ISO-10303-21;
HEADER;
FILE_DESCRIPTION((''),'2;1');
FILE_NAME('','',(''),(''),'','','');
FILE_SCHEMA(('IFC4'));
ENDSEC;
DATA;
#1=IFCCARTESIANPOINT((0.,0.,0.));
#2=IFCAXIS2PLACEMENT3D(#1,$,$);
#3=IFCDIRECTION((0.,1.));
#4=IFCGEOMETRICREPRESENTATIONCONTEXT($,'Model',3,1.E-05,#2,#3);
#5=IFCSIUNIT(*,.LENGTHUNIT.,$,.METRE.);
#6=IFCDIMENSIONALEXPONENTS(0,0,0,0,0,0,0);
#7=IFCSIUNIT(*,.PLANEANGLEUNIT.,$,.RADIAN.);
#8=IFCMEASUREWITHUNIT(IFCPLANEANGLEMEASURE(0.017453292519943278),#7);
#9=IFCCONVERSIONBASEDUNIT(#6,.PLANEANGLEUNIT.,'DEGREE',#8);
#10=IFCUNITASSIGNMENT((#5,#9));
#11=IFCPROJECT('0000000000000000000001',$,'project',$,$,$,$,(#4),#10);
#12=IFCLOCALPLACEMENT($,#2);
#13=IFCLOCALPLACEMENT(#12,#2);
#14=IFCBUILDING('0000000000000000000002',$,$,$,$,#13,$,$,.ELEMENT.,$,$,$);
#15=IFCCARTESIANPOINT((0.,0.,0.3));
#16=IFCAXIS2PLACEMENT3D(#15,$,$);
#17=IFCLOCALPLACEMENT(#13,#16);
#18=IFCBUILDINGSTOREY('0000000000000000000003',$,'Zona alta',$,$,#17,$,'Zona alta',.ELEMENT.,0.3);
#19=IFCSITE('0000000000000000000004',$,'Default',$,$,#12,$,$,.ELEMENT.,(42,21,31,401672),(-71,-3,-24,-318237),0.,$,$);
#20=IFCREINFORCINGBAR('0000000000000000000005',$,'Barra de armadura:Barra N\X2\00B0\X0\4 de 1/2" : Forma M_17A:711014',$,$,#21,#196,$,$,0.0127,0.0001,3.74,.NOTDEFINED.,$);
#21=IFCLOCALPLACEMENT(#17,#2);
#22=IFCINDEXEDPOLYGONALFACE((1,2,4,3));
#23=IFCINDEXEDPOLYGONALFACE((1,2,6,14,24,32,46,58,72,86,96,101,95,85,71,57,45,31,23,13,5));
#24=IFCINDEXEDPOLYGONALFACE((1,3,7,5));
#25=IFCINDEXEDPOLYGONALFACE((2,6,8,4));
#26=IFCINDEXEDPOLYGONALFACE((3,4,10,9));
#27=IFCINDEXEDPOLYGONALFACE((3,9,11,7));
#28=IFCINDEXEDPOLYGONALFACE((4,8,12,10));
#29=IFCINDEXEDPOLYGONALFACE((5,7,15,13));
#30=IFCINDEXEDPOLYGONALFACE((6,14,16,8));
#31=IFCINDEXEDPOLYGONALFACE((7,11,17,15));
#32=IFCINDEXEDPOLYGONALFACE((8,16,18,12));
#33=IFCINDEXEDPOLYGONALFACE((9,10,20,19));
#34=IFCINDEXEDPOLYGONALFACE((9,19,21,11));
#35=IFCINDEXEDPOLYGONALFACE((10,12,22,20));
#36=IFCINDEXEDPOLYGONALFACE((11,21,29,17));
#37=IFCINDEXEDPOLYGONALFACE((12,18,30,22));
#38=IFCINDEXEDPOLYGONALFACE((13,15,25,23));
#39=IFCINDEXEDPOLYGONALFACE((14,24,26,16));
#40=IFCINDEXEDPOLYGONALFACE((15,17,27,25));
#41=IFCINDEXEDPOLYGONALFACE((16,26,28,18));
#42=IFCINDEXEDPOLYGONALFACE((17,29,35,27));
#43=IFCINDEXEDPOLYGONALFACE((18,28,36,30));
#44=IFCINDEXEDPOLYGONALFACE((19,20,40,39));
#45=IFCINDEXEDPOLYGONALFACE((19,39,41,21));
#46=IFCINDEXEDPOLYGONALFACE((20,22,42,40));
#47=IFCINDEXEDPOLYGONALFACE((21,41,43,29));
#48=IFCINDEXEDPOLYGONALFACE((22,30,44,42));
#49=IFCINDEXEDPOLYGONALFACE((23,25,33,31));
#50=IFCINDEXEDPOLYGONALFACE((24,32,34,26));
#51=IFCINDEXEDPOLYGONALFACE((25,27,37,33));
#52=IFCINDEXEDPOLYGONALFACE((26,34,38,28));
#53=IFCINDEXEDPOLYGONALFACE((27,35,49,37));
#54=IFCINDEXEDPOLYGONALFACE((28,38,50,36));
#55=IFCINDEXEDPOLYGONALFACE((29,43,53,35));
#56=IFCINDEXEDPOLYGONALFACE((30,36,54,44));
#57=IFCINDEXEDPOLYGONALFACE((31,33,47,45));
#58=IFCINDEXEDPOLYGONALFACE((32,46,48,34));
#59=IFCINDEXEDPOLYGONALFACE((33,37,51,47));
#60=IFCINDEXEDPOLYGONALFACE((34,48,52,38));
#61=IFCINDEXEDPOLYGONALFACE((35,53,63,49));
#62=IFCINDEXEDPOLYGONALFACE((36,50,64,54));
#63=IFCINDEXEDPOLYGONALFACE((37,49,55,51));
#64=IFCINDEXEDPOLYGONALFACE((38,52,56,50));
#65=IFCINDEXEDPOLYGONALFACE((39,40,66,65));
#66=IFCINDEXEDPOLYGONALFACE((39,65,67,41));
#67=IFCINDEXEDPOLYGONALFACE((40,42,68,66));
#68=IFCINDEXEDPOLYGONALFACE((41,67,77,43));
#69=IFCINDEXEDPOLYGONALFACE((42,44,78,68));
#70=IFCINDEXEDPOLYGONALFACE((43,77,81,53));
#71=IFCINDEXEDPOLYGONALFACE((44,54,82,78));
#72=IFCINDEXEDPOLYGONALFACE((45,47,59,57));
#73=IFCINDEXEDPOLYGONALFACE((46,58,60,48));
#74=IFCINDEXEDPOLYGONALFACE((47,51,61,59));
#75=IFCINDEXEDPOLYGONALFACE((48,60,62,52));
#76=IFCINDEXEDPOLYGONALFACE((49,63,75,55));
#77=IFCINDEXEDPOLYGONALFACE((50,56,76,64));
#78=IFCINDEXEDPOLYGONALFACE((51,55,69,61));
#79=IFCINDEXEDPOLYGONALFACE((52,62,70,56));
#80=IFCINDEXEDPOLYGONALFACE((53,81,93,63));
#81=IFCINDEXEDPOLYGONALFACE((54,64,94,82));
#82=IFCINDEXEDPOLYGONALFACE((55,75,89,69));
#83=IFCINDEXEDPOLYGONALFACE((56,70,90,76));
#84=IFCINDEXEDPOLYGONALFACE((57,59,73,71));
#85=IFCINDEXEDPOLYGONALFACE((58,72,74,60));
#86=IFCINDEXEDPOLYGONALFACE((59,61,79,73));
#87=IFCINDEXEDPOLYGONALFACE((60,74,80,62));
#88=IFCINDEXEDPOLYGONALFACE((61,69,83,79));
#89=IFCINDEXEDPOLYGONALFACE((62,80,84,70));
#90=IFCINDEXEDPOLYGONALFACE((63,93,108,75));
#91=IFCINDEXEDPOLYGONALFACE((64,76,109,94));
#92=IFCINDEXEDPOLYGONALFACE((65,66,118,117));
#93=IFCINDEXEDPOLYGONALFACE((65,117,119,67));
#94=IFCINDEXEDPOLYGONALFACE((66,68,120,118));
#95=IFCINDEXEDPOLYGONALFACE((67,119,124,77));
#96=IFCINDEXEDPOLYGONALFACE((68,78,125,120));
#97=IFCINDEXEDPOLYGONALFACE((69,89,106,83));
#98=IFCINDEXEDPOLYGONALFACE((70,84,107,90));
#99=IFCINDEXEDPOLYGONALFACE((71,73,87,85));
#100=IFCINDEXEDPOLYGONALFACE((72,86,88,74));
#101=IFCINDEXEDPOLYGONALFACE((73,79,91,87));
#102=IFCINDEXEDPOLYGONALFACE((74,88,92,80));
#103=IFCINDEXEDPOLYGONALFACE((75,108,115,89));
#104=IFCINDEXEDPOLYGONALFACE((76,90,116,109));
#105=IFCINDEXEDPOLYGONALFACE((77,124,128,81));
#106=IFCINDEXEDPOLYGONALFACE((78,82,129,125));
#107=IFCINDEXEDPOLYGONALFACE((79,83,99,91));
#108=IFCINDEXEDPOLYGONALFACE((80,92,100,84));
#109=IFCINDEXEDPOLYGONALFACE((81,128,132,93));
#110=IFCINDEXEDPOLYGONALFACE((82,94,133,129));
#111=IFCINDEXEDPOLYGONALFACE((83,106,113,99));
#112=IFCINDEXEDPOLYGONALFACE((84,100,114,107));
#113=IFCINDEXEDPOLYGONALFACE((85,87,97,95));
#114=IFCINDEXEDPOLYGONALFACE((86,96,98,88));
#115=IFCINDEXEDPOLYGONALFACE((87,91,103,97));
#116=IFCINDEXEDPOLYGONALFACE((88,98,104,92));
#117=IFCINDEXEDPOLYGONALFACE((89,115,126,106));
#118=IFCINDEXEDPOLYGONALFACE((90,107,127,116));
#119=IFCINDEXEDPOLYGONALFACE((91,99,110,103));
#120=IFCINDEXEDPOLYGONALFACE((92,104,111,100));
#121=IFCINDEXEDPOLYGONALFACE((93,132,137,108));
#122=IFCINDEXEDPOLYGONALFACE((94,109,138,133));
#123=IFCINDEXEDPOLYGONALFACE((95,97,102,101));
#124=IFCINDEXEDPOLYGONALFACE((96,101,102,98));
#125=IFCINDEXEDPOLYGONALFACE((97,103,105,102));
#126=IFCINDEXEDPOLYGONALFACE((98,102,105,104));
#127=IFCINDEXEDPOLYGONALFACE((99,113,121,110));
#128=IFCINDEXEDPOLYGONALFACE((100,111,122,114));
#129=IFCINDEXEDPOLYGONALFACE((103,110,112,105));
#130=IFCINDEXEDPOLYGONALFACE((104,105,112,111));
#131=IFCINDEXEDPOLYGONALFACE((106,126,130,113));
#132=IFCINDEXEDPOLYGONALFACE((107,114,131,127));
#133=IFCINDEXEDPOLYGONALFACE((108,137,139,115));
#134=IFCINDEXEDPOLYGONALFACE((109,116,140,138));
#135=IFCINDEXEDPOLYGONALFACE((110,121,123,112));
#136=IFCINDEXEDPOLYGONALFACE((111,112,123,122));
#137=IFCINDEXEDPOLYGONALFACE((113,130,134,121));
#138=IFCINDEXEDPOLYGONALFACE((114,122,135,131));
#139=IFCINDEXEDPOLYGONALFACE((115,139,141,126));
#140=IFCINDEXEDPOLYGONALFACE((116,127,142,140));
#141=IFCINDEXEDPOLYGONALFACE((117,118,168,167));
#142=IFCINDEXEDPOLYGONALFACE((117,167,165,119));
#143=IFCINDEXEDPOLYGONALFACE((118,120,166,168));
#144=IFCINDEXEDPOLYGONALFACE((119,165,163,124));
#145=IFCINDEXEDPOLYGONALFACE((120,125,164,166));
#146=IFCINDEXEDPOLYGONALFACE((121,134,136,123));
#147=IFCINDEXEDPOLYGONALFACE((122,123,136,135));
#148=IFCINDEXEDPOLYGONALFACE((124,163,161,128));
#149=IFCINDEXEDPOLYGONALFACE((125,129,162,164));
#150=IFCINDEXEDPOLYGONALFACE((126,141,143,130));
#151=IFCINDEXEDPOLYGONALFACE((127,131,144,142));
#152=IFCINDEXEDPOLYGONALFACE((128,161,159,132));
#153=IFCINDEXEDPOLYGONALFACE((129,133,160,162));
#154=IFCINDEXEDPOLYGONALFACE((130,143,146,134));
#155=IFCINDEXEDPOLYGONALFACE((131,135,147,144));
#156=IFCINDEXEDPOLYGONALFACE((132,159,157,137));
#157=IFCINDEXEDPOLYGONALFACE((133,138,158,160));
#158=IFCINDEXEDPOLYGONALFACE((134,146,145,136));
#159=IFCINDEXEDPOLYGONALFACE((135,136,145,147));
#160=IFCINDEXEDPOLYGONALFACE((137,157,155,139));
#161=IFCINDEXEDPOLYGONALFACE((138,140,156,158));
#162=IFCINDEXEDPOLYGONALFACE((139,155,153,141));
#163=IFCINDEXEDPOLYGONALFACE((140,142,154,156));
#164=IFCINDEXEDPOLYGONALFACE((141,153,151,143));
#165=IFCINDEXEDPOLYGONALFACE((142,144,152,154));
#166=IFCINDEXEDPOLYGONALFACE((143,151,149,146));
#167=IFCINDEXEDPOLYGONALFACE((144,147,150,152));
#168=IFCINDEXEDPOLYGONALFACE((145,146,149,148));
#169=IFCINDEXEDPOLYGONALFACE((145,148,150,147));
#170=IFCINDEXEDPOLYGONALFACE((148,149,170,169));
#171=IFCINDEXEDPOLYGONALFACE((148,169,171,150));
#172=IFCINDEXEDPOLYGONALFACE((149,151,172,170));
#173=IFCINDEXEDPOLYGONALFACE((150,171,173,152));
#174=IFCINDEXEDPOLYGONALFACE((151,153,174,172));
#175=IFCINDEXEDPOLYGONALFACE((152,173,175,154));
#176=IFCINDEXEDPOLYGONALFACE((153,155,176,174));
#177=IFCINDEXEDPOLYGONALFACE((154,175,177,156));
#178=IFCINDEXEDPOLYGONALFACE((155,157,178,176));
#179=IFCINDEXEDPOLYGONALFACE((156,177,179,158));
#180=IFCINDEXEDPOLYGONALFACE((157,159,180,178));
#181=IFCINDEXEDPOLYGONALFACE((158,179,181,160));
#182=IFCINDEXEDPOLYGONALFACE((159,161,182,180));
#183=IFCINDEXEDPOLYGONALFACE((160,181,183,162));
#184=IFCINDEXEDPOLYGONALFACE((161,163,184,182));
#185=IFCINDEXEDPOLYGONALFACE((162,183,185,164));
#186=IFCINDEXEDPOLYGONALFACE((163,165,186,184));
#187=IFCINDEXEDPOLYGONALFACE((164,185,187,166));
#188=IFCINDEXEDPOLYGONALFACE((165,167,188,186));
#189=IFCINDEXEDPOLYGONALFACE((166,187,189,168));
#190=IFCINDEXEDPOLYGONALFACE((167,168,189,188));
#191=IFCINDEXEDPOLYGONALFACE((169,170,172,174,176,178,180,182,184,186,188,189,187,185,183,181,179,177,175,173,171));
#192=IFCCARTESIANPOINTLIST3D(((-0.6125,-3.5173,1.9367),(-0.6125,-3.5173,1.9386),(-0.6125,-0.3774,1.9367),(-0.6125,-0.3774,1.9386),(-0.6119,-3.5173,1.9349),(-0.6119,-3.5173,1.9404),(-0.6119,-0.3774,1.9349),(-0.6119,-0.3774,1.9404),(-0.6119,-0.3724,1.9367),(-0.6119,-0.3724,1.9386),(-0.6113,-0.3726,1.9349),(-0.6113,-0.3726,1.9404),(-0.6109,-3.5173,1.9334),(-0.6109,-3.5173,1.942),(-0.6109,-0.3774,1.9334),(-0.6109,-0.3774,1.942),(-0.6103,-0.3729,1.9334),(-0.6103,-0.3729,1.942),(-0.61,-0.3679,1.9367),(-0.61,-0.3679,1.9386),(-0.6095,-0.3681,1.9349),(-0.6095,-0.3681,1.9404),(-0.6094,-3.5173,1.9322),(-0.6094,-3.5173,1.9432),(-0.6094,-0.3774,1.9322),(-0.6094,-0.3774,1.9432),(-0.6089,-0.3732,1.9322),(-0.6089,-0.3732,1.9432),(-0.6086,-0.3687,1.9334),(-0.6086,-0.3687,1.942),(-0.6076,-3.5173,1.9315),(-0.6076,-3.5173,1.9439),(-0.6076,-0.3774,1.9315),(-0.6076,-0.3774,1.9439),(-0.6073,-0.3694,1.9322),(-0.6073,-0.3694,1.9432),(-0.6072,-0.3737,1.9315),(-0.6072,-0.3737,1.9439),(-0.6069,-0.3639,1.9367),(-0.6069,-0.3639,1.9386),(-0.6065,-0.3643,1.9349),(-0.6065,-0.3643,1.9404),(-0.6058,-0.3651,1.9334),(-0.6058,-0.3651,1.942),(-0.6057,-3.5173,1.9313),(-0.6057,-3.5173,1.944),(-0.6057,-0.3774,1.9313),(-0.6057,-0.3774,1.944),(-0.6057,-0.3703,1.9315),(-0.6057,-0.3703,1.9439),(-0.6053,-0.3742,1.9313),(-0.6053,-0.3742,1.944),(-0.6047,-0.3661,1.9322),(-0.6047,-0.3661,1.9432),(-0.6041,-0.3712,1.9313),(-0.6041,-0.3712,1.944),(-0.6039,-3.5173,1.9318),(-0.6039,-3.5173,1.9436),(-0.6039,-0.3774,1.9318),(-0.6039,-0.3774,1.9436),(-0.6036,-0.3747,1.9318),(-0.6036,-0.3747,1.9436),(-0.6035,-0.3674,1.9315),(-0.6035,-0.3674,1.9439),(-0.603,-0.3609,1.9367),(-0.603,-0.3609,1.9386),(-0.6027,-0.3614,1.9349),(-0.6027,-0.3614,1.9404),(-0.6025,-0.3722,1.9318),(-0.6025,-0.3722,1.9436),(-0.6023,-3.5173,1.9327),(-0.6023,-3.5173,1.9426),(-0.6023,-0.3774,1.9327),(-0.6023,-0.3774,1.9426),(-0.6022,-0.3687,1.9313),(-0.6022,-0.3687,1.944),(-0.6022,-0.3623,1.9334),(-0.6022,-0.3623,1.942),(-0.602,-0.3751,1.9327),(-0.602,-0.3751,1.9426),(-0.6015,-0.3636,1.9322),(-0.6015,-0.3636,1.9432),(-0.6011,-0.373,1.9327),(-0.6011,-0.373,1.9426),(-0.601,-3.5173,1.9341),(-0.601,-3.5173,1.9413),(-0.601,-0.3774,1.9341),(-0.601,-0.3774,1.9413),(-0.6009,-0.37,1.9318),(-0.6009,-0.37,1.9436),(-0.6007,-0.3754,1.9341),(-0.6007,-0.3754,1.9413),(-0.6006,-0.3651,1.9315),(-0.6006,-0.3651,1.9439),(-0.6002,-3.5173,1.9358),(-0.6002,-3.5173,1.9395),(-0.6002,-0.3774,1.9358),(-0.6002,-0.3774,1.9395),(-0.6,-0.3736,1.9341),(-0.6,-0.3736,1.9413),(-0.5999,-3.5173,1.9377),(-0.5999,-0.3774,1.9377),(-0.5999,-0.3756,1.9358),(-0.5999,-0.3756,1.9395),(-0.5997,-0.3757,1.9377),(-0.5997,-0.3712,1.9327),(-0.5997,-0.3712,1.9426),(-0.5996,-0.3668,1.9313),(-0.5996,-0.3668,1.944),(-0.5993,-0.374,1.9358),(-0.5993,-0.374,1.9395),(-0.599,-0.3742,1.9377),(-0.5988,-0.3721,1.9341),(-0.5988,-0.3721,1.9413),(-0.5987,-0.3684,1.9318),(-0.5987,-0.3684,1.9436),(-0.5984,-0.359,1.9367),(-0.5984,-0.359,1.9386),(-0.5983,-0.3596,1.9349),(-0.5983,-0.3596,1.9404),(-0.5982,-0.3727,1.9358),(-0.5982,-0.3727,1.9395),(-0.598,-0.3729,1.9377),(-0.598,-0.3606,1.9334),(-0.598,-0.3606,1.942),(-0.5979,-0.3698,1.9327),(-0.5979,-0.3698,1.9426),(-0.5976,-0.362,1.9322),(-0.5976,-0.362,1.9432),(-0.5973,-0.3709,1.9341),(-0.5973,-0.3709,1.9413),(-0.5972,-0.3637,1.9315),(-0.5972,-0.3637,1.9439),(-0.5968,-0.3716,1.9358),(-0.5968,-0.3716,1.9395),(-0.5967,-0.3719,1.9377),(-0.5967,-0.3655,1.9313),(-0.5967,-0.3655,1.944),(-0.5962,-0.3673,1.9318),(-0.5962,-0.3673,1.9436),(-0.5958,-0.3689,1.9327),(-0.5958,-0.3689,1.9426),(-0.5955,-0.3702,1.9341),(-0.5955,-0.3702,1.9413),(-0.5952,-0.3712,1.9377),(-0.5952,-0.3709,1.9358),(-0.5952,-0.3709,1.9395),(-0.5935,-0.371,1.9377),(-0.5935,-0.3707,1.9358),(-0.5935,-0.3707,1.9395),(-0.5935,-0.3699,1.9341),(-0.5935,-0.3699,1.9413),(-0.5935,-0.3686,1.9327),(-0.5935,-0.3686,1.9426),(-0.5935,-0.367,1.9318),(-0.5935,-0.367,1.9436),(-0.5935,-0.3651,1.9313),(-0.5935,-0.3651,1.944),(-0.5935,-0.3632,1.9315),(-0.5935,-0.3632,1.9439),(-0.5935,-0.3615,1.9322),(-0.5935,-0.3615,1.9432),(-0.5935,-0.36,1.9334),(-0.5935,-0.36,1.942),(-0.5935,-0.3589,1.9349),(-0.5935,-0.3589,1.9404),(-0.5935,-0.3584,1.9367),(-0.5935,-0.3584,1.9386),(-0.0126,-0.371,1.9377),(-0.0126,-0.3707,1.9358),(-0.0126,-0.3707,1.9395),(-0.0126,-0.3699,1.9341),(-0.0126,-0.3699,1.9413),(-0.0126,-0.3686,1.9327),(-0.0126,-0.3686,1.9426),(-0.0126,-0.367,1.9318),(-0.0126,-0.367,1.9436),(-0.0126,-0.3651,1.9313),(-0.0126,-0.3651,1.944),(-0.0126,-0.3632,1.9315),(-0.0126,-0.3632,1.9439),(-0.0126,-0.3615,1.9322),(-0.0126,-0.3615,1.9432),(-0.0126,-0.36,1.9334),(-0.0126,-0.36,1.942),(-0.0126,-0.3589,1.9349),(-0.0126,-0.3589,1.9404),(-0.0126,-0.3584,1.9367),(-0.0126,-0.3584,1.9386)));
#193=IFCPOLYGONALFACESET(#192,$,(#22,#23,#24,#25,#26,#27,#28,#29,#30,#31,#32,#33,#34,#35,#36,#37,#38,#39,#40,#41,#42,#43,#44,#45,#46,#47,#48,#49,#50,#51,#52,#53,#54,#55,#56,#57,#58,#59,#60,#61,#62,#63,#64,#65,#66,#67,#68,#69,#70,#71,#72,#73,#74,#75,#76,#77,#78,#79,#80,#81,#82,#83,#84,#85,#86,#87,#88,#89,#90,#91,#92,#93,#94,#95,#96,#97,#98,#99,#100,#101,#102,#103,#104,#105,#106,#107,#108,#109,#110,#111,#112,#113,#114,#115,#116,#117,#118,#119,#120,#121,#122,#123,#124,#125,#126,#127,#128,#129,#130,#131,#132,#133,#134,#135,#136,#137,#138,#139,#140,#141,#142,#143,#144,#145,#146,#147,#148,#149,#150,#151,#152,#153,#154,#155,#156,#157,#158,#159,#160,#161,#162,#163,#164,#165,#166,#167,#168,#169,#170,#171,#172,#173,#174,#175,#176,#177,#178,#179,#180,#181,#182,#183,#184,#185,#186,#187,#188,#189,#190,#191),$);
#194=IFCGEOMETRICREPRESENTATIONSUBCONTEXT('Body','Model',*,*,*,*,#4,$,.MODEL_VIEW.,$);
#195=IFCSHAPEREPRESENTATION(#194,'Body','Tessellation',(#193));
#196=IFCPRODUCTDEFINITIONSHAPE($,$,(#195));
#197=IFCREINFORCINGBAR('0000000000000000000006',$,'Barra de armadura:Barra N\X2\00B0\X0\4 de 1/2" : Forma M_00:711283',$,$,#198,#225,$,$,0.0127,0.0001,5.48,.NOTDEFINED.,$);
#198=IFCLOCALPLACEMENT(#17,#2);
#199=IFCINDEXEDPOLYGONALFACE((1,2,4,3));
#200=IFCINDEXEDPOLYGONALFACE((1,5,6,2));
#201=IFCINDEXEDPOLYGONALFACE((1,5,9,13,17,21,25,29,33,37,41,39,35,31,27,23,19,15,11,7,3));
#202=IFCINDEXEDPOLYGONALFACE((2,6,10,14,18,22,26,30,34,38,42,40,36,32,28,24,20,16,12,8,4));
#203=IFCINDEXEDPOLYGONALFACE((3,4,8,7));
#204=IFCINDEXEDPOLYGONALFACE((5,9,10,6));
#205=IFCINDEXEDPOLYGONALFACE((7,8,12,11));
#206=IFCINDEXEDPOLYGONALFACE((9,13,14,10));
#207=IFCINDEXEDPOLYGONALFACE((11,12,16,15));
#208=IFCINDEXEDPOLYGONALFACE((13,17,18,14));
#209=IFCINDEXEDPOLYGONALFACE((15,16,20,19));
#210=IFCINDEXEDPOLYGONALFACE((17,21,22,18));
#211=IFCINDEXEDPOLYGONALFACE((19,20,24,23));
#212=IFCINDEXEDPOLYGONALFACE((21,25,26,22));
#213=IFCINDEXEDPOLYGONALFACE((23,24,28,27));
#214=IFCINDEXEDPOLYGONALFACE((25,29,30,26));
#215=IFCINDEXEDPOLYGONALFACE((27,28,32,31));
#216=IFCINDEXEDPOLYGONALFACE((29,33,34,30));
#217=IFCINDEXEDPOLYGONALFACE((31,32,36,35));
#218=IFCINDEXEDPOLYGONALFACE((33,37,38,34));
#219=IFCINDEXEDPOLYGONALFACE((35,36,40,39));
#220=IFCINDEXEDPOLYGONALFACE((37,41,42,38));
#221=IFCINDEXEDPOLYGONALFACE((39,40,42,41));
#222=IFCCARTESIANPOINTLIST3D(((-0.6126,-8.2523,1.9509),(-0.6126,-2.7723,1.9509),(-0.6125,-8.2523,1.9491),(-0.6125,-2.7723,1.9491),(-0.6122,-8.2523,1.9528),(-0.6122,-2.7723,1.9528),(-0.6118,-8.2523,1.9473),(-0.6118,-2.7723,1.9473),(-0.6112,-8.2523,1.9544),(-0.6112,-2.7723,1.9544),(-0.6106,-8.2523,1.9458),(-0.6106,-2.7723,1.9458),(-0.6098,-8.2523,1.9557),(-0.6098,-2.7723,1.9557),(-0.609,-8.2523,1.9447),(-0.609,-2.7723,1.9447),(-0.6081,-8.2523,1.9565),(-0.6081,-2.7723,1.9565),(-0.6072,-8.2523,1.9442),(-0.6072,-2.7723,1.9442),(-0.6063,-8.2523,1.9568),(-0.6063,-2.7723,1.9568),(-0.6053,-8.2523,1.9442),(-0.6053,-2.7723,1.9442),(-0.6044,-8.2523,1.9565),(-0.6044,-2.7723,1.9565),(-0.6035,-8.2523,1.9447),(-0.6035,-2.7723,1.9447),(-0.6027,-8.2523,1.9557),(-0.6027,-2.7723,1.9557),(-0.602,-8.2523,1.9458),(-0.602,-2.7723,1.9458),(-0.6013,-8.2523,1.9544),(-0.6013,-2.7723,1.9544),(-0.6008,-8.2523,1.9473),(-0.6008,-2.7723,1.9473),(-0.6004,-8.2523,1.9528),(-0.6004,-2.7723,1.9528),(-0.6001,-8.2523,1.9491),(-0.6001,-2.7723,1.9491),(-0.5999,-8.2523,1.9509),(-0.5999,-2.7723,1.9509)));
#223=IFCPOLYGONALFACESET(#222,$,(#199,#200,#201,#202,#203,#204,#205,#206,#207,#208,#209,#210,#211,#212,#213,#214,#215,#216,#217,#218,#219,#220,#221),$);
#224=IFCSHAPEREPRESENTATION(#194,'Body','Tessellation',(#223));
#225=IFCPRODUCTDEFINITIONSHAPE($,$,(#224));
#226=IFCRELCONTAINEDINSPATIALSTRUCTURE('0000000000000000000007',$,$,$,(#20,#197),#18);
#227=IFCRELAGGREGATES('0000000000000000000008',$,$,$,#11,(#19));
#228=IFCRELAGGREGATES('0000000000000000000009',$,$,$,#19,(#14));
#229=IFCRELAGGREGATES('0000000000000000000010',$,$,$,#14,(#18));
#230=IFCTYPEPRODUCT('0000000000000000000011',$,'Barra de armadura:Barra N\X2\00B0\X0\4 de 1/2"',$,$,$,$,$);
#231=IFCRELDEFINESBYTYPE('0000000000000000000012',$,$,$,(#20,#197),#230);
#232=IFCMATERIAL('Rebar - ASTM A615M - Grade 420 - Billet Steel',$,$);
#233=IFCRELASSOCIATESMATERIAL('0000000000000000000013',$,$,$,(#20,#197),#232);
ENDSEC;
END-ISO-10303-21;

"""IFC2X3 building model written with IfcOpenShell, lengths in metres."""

from ifc_helpers import new_model, entity, si_unit, converted_unit, direction, frame, origin, place, context, subcontext, project, spatial, material, type_object, element, save


model = new_model("IFC2X3")

# Units and contexts
model_context = context("Model", 3, precision=1e-05, world=origin(), true_north=direction((0.0, 1.0)))
body_context = subcontext(model_context, "Body", "Model", "MODEL_VIEW")
ifc_project = project(units=[si_unit("LENGTHUNIT", "METRE"), converted_unit("PLANEANGLEUNIT", "DEGREE", entity("IfcPlaneAngleMeasure", 0.017453292519943278), si_unit("PLANEANGLEUNIT", "RADIAN"), dimensions=[0, 0, 0, 0, 0, 0, 0])], contexts=[model_context])

# Site, building, storey
site_placement = place(None, origin())
site = spatial("IfcSite", under=ifc_project, at=site_placement, Name="Default", CompositionType="ELEMENT", RefLatitude=(42, 21, 31, 401672), RefLongitude=(-71, -3, -24, -318237), RefElevation=0.0)
building_placement = place(site_placement, origin())
building = spatial("IfcBuilding", under=site, at=building_placement, CompositionType="ELEMENT")
storey_placement = place(building_placement, frame((0.0, 0.0, 0.3)))
storey = spatial("IfcBuildingStorey", under=building, at=storey_placement, Name="Zona alta", LongName="Zona alta", CompositionType="ELEMENT", Elevation=0.3)

# Reinforcing bars
ifc_material = material(Name="Rebar - ASTM A615M - Grade 420 - Billet Steel")
type_product_1 = type_object("IfcTypeProduct", Name="Barra de armadura:Barra N°4 de 1/2\"")
reinforcing_bar_1_placement = place(storey_placement, origin())
element("IfcReinforcingBar", 1, at=reinforcing_bar_1_placement, inside=storey, type_object=type_product_1, material=ifc_material, Name="Barra de armadura:Barra N°4 de 1/2\" : Forma M_17A:711014", BarLength=3.74, BarRole="NOTDEFINED", CrossSectionArea=0.0001, NominalDiameter=0.0127, context=body_context, shape_type="AdvancedSweptSolid", body=[
    entity("IfcSweptDiskSolid", entity("IfcCompositeCurve", [entity("IfcCompositeCurveSegment", "CONTINUOUS", True, entity("IfcPolyline", [entity("IfcCartesianPoint", [-0.6062, -3.5173, 1.9377]), entity("IfcCartesianPoint", [-0.6062, -0.3774, 1.9377])])), entity("IfcCompositeCurveSegment", "CONTINUOUS", True, entity("IfcTrimmedCurve", entity("IfcCircle", entity("IfcAxis2Placement3D", entity("IfcCartesianPoint", [-0.5935, -0.3774, 1.9377]), entity("IfcDirection", [0.0, 0.0, -1.0]), entity("IfcDirection", [0.0, 1.0, 0.0])), 0.0127), [entity("IfcParameterValue", 270.0)], [entity("IfcParameterValue", 360.0)], True, "PARAMETER")), entity("IfcCompositeCurveSegment", "CONTINUOUS", True, entity("IfcPolyline", [entity("IfcCartesianPoint", [-0.5935, -0.3647, 1.9377]), entity("IfcCartesianPoint", [-0.0126, -0.3647, 1.9377])]))], False), 0.0063, None, 0.0, 92.0),
])
reinforcing_bar_2_placement = place(storey_placement, origin())
element("IfcReinforcingBar", 2, at=reinforcing_bar_2_placement, inside=storey, type_object=type_product_1, material=ifc_material, Name="Barra de armadura:Barra N°4 de 1/2\" : Forma M_00:711283", BarLength=5.48, BarRole="NOTDEFINED", CrossSectionArea=0.0001, NominalDiameter=0.0127, context=body_context, shape_type="AdvancedSweptSolid", body=[
    entity("IfcSweptDiskSolid", entity("IfcCompositeCurve", [entity("IfcCompositeCurveSegment", "CONTINUOUS", True, entity("IfcPolyline", [entity("IfcCartesianPoint", [-0.6063, -8.2523, 1.9505]), entity("IfcCartesianPoint", [-0.6063, -2.7723, 1.9505])]))], False), 0.0063, None, 0.0, 1.0),
])

save(model, "model.ifc")
